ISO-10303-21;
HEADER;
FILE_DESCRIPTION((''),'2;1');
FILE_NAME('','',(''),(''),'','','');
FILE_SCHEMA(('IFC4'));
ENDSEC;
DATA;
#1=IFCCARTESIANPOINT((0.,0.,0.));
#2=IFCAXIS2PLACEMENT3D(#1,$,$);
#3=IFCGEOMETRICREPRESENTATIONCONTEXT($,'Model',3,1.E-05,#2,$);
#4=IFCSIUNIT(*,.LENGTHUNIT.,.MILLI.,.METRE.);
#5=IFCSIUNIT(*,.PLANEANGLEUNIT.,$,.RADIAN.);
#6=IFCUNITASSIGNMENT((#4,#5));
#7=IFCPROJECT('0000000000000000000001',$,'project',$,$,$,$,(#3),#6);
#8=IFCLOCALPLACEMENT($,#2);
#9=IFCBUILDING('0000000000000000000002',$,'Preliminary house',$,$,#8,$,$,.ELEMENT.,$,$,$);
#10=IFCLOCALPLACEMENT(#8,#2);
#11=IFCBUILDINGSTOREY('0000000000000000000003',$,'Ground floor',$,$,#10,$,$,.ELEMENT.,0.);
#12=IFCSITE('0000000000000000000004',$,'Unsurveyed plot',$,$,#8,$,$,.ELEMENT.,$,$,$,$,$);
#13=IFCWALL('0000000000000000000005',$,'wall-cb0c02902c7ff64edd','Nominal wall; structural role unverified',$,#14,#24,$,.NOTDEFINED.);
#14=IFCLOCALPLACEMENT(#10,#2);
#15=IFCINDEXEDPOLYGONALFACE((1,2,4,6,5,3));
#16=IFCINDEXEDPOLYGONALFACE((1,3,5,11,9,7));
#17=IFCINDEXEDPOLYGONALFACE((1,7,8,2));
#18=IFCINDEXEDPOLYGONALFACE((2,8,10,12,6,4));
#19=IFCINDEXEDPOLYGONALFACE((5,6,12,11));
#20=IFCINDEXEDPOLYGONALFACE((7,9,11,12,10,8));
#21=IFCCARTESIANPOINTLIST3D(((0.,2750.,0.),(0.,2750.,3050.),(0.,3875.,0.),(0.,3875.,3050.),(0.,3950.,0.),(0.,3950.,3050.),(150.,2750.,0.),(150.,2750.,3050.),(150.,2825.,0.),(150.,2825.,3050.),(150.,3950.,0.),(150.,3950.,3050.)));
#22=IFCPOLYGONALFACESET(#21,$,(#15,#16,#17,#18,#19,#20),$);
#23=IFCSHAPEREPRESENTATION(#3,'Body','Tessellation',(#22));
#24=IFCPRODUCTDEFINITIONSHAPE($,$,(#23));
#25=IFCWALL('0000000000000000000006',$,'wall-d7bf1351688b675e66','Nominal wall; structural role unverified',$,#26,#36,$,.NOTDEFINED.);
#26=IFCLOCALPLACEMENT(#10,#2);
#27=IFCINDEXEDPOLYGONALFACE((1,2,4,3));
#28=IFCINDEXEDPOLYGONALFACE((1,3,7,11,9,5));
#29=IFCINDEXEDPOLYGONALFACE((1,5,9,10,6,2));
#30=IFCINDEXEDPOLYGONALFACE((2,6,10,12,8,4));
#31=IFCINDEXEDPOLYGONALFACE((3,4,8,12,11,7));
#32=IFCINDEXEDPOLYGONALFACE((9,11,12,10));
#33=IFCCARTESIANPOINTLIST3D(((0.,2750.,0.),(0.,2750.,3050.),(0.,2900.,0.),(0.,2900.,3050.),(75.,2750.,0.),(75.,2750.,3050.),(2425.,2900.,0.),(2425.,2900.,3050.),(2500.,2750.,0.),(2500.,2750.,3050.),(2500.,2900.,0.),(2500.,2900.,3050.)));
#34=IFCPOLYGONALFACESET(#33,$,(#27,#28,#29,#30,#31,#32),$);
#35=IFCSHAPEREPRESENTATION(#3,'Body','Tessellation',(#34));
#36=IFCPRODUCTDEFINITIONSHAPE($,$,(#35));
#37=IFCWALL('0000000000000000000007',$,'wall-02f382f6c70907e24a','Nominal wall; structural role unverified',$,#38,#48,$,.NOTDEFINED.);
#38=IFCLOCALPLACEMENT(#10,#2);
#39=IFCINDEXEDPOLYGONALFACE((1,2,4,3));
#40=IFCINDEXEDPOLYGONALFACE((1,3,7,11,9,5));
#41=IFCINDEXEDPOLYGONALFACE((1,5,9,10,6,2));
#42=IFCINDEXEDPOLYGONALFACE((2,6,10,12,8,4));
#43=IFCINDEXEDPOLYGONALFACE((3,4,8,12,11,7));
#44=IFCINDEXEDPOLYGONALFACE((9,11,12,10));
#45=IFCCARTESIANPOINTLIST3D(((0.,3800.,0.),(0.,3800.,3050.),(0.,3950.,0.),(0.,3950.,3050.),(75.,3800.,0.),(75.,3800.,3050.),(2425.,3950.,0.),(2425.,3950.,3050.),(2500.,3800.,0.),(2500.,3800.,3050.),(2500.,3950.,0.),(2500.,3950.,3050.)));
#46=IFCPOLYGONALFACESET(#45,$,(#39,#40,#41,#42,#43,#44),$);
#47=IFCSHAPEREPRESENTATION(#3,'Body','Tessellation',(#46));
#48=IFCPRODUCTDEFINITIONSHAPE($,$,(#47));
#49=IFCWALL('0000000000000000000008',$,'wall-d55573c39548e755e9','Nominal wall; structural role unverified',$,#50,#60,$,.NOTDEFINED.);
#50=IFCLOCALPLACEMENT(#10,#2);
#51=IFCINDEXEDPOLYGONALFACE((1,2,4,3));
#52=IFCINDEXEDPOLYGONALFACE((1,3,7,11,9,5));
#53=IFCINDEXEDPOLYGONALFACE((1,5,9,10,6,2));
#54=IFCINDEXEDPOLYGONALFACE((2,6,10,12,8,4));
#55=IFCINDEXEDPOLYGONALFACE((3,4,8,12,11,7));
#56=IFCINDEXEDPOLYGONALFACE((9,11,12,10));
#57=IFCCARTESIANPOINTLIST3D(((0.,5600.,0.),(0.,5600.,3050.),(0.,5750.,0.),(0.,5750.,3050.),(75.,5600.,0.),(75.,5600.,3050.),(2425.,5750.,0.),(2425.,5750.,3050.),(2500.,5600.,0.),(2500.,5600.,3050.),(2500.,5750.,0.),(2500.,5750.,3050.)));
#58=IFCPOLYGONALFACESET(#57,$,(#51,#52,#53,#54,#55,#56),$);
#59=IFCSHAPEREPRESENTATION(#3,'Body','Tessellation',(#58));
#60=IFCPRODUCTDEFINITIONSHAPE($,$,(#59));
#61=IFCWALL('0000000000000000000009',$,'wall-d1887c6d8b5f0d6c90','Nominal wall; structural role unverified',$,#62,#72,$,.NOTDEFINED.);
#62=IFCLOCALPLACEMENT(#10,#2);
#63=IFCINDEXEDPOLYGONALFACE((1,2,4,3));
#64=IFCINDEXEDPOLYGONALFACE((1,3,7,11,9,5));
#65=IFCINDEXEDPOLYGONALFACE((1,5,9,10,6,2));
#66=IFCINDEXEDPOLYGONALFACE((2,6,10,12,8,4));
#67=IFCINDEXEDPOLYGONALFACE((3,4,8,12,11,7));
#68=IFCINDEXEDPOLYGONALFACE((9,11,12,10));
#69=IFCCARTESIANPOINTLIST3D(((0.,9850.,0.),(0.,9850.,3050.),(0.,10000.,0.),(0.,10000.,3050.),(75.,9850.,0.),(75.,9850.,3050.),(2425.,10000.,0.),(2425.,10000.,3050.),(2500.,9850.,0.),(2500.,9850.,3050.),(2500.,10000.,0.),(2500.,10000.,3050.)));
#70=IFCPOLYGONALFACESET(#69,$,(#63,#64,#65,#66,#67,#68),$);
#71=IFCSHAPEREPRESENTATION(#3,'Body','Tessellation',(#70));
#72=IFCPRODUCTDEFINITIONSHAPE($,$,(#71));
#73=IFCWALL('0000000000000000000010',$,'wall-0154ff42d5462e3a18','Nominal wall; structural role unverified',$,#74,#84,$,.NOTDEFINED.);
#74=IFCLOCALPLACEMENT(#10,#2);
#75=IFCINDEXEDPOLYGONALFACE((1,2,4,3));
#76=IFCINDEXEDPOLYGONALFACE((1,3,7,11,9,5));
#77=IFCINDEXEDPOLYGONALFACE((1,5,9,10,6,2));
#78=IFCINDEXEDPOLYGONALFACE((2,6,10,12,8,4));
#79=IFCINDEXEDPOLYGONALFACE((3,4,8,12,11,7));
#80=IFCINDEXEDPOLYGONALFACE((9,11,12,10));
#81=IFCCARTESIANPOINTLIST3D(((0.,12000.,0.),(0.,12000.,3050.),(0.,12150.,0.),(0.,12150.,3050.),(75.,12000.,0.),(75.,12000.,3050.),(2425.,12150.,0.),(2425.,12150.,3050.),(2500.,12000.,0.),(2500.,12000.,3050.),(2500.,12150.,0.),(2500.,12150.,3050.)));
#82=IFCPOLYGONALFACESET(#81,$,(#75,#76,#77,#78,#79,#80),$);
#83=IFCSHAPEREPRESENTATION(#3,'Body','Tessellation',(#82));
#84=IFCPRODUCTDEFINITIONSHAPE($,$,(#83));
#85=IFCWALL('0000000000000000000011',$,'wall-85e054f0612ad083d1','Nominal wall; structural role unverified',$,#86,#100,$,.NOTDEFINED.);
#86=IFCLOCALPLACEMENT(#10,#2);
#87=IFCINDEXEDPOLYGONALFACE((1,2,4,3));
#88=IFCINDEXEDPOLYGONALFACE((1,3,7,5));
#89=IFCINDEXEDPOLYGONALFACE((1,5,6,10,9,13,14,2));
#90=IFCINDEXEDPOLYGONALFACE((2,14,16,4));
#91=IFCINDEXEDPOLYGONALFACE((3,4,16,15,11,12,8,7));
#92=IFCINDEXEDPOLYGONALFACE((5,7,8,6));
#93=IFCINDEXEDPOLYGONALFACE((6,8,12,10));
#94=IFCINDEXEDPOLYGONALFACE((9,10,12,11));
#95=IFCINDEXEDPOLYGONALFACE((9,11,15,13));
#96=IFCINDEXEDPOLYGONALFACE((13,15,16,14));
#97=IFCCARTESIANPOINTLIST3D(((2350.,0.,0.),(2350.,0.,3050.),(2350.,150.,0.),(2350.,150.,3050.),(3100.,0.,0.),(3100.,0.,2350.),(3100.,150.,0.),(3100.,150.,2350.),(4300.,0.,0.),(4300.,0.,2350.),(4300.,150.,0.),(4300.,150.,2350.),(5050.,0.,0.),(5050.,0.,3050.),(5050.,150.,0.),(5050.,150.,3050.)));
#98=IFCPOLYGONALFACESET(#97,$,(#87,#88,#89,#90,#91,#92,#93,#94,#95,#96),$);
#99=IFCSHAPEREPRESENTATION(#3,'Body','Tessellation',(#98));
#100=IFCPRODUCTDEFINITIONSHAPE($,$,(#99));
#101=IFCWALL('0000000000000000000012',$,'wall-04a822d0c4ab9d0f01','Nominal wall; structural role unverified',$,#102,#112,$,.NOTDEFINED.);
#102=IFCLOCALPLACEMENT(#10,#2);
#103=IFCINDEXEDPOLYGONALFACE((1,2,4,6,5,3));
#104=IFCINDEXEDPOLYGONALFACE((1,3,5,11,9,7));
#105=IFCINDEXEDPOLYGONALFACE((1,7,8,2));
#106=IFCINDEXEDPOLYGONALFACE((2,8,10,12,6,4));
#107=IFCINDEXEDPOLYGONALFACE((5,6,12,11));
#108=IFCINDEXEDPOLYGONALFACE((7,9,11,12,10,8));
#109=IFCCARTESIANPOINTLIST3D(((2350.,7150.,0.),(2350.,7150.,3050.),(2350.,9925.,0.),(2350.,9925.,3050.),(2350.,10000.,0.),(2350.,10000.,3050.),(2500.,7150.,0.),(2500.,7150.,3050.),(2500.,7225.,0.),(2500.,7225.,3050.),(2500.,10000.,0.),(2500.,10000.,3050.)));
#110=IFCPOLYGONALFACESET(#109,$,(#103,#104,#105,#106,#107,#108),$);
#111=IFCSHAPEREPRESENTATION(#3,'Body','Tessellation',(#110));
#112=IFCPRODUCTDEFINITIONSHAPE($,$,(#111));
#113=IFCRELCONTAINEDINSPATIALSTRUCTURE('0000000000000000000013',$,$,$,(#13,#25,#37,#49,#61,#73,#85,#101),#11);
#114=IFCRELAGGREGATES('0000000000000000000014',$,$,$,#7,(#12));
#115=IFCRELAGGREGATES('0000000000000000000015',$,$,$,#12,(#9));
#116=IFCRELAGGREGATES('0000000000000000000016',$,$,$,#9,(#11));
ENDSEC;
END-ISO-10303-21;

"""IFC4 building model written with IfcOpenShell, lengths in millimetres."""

from ifc_helpers import new_model, si_unit, origin, place, context, project, spatial, polyline, outline, extrude, element, save


model = new_model("IFC4")

# Units and contexts
model_context = context("Model", 3, precision=1e-05, world=origin())
ifc_project = project(units=[si_unit("LENGTHUNIT", "METRE", prefix="MILLI"), si_unit("PLANEANGLEUNIT", "RADIAN")], contexts=[model_context])

# Site, building, storey
placement_1 = place(None, origin())
site = spatial("IfcSite", under=ifc_project, at=placement_1, Name="Unsurveyed plot", CompositionType="ELEMENT")
building = spatial("IfcBuilding", under=site, at=placement_1, Name="Preliminary house", CompositionType="ELEMENT")
placement_2 = place(placement_1, origin())
storey = spatial("IfcBuildingStorey", under=building, at=placement_2, Name="Ground floor", CompositionType="ELEMENT", Elevation=0.0)

# Walls
element("IfcWall", 1, at=placement_2, inside=storey, Name="wall-cb0c02902c7ff64edd", Description="Nominal wall; structural role unverified", PredefinedType="NOTDEFINED", context=model_context, shape_type="SweptSolid", body=[
    extrude(outline(polyline([(0.0, 3875.0), (0.0, 3950.0), (150.0, 3950.0), (150.0, 2825.0), (150.0, 2750.0), (0.0, 2750.0), (0.0, 3875.0)])), origin(), (0.0, 0.0, 1.0), 3050.0),
])
element("IfcWall", 2, at=placement_2, inside=storey, Name="wall-d7bf1351688b675e66", Description="Nominal wall; structural role unverified", PredefinedType="NOTDEFINED", context=model_context, shape_type="SweptSolid", body=[
    extrude(outline(polyline([(2425.0, 2900.0), (2500.0, 2900.0), (2500.0, 2750.0), (75.0, 2750.0), (0.0, 2750.0), (0.0, 2900.0), (2425.0, 2900.0)])), origin(), (0.0, 0.0, 1.0), 3050.0),
])

# Wall
element("IfcWall", 3, at=placement_2, inside=storey, Name="wall-02f382f6c70907e24a", Description="Nominal wall; structural role unverified", PredefinedType="NOTDEFINED", context=model_context, shape_type="SweptSolid", body=[
    extrude(outline(polyline([(2425.0, 3950.0), (2500.0, 3950.0), (2500.0, 3800.0), (75.0, 3800.0), (0.0, 3800.0), (0.0, 3950.0), (2425.0, 3950.0)])), origin(), (0.0, 0.0, 1.0), 3050.0),
])

# Wall
element("IfcWall", 4, at=placement_2, inside=storey, Name="wall-d55573c39548e755e9", Description="Nominal wall; structural role unverified", PredefinedType="NOTDEFINED", context=model_context, shape_type="SweptSolid", body=[
    extrude(outline(polyline([(2425.0, 5750.0), (2500.0, 5750.0), (2500.0, 5600.0), (75.0, 5600.0), (0.0, 5600.0), (0.0, 5750.0), (2425.0, 5750.0)])), origin(), (0.0, 0.0, 1.0), 3050.0),
])

# Walls
element("IfcWall", 5, at=placement_2, inside=storey, Name="wall-d1887c6d8b5f0d6c90", Description="Nominal wall; structural role unverified", PredefinedType="NOTDEFINED", context=model_context, shape_type="SweptSolid", body=[
    extrude(outline(polyline([(2425.0, 10000.0), (2500.0, 10000.0), (2500.0, 9850.0), (75.0, 9850.0), (0.0, 9850.0), (0.0, 10000.0), (2425.0, 10000.0)])), origin(), (0.0, 0.0, 1.0), 3050.0),
])
element("IfcWall", 6, at=placement_2, inside=storey, Name="wall-0154ff42d5462e3a18", Description="Nominal wall; structural role unverified", PredefinedType="NOTDEFINED", context=model_context, shape_type="SweptSolid", body=[
    extrude(outline(polyline([(2425.0, 12150.0), (2500.0, 12150.0), (2500.0, 12000.0), (75.0, 12000.0), (0.0, 12000.0), (0.0, 12150.0), (2425.0, 12150.0)])), origin(), (0.0, 0.0, 1.0), 3050.0),
])

# Wall, opening
wall_1 = element("IfcWall", 7, at=placement_2, inside=storey, Name="wall-85e054f0612ad083d1", Description="Nominal wall; structural role unverified", PredefinedType="NOTDEFINED", context=model_context, shape_type="SweptSolid", body=[
    extrude(outline(polyline([(4975.0, 150.0), (5050.0, 150.0), (5050.0, 0.0), (2425.0, 0.0), (2350.0, 0.0), (2350.0, 150.0), (4975.0, 150.0)])), origin(), (0.0, 0.0, 1.0), 3050.0),
])
element("IfcOpeningElement", 8, at=placement_2, cuts=wall_1, PredefinedType="OPENING", context=model_context, shape_type="SweptSolid", body=[
    extrude(outline(polyline([(3100.0, -375.0), (4300.0, -375.0), (4300.0, 525.0), (3100.0, 525.0), (3100.0, -375.0)])), origin(), (0.0, 0.0, 1.0), 2350.0),
])

# Wall
element("IfcWall", 9, at=placement_2, inside=storey, Name="wall-04a822d0c4ab9d0f01", Description="Nominal wall; structural role unverified", PredefinedType="NOTDEFINED", context=model_context, shape_type="SweptSolid", body=[
    extrude(outline(polyline([(2350.0, 9925.0), (2350.0, 10000.0), (2500.0, 10000.0), (2500.0, 7225.0), (2500.0, 7150.0), (2350.0, 7150.0), (2350.0, 9925.0)])), origin(), (0.0, 0.0, 1.0), 3050.0),
])

save(model, "model.ifc")
